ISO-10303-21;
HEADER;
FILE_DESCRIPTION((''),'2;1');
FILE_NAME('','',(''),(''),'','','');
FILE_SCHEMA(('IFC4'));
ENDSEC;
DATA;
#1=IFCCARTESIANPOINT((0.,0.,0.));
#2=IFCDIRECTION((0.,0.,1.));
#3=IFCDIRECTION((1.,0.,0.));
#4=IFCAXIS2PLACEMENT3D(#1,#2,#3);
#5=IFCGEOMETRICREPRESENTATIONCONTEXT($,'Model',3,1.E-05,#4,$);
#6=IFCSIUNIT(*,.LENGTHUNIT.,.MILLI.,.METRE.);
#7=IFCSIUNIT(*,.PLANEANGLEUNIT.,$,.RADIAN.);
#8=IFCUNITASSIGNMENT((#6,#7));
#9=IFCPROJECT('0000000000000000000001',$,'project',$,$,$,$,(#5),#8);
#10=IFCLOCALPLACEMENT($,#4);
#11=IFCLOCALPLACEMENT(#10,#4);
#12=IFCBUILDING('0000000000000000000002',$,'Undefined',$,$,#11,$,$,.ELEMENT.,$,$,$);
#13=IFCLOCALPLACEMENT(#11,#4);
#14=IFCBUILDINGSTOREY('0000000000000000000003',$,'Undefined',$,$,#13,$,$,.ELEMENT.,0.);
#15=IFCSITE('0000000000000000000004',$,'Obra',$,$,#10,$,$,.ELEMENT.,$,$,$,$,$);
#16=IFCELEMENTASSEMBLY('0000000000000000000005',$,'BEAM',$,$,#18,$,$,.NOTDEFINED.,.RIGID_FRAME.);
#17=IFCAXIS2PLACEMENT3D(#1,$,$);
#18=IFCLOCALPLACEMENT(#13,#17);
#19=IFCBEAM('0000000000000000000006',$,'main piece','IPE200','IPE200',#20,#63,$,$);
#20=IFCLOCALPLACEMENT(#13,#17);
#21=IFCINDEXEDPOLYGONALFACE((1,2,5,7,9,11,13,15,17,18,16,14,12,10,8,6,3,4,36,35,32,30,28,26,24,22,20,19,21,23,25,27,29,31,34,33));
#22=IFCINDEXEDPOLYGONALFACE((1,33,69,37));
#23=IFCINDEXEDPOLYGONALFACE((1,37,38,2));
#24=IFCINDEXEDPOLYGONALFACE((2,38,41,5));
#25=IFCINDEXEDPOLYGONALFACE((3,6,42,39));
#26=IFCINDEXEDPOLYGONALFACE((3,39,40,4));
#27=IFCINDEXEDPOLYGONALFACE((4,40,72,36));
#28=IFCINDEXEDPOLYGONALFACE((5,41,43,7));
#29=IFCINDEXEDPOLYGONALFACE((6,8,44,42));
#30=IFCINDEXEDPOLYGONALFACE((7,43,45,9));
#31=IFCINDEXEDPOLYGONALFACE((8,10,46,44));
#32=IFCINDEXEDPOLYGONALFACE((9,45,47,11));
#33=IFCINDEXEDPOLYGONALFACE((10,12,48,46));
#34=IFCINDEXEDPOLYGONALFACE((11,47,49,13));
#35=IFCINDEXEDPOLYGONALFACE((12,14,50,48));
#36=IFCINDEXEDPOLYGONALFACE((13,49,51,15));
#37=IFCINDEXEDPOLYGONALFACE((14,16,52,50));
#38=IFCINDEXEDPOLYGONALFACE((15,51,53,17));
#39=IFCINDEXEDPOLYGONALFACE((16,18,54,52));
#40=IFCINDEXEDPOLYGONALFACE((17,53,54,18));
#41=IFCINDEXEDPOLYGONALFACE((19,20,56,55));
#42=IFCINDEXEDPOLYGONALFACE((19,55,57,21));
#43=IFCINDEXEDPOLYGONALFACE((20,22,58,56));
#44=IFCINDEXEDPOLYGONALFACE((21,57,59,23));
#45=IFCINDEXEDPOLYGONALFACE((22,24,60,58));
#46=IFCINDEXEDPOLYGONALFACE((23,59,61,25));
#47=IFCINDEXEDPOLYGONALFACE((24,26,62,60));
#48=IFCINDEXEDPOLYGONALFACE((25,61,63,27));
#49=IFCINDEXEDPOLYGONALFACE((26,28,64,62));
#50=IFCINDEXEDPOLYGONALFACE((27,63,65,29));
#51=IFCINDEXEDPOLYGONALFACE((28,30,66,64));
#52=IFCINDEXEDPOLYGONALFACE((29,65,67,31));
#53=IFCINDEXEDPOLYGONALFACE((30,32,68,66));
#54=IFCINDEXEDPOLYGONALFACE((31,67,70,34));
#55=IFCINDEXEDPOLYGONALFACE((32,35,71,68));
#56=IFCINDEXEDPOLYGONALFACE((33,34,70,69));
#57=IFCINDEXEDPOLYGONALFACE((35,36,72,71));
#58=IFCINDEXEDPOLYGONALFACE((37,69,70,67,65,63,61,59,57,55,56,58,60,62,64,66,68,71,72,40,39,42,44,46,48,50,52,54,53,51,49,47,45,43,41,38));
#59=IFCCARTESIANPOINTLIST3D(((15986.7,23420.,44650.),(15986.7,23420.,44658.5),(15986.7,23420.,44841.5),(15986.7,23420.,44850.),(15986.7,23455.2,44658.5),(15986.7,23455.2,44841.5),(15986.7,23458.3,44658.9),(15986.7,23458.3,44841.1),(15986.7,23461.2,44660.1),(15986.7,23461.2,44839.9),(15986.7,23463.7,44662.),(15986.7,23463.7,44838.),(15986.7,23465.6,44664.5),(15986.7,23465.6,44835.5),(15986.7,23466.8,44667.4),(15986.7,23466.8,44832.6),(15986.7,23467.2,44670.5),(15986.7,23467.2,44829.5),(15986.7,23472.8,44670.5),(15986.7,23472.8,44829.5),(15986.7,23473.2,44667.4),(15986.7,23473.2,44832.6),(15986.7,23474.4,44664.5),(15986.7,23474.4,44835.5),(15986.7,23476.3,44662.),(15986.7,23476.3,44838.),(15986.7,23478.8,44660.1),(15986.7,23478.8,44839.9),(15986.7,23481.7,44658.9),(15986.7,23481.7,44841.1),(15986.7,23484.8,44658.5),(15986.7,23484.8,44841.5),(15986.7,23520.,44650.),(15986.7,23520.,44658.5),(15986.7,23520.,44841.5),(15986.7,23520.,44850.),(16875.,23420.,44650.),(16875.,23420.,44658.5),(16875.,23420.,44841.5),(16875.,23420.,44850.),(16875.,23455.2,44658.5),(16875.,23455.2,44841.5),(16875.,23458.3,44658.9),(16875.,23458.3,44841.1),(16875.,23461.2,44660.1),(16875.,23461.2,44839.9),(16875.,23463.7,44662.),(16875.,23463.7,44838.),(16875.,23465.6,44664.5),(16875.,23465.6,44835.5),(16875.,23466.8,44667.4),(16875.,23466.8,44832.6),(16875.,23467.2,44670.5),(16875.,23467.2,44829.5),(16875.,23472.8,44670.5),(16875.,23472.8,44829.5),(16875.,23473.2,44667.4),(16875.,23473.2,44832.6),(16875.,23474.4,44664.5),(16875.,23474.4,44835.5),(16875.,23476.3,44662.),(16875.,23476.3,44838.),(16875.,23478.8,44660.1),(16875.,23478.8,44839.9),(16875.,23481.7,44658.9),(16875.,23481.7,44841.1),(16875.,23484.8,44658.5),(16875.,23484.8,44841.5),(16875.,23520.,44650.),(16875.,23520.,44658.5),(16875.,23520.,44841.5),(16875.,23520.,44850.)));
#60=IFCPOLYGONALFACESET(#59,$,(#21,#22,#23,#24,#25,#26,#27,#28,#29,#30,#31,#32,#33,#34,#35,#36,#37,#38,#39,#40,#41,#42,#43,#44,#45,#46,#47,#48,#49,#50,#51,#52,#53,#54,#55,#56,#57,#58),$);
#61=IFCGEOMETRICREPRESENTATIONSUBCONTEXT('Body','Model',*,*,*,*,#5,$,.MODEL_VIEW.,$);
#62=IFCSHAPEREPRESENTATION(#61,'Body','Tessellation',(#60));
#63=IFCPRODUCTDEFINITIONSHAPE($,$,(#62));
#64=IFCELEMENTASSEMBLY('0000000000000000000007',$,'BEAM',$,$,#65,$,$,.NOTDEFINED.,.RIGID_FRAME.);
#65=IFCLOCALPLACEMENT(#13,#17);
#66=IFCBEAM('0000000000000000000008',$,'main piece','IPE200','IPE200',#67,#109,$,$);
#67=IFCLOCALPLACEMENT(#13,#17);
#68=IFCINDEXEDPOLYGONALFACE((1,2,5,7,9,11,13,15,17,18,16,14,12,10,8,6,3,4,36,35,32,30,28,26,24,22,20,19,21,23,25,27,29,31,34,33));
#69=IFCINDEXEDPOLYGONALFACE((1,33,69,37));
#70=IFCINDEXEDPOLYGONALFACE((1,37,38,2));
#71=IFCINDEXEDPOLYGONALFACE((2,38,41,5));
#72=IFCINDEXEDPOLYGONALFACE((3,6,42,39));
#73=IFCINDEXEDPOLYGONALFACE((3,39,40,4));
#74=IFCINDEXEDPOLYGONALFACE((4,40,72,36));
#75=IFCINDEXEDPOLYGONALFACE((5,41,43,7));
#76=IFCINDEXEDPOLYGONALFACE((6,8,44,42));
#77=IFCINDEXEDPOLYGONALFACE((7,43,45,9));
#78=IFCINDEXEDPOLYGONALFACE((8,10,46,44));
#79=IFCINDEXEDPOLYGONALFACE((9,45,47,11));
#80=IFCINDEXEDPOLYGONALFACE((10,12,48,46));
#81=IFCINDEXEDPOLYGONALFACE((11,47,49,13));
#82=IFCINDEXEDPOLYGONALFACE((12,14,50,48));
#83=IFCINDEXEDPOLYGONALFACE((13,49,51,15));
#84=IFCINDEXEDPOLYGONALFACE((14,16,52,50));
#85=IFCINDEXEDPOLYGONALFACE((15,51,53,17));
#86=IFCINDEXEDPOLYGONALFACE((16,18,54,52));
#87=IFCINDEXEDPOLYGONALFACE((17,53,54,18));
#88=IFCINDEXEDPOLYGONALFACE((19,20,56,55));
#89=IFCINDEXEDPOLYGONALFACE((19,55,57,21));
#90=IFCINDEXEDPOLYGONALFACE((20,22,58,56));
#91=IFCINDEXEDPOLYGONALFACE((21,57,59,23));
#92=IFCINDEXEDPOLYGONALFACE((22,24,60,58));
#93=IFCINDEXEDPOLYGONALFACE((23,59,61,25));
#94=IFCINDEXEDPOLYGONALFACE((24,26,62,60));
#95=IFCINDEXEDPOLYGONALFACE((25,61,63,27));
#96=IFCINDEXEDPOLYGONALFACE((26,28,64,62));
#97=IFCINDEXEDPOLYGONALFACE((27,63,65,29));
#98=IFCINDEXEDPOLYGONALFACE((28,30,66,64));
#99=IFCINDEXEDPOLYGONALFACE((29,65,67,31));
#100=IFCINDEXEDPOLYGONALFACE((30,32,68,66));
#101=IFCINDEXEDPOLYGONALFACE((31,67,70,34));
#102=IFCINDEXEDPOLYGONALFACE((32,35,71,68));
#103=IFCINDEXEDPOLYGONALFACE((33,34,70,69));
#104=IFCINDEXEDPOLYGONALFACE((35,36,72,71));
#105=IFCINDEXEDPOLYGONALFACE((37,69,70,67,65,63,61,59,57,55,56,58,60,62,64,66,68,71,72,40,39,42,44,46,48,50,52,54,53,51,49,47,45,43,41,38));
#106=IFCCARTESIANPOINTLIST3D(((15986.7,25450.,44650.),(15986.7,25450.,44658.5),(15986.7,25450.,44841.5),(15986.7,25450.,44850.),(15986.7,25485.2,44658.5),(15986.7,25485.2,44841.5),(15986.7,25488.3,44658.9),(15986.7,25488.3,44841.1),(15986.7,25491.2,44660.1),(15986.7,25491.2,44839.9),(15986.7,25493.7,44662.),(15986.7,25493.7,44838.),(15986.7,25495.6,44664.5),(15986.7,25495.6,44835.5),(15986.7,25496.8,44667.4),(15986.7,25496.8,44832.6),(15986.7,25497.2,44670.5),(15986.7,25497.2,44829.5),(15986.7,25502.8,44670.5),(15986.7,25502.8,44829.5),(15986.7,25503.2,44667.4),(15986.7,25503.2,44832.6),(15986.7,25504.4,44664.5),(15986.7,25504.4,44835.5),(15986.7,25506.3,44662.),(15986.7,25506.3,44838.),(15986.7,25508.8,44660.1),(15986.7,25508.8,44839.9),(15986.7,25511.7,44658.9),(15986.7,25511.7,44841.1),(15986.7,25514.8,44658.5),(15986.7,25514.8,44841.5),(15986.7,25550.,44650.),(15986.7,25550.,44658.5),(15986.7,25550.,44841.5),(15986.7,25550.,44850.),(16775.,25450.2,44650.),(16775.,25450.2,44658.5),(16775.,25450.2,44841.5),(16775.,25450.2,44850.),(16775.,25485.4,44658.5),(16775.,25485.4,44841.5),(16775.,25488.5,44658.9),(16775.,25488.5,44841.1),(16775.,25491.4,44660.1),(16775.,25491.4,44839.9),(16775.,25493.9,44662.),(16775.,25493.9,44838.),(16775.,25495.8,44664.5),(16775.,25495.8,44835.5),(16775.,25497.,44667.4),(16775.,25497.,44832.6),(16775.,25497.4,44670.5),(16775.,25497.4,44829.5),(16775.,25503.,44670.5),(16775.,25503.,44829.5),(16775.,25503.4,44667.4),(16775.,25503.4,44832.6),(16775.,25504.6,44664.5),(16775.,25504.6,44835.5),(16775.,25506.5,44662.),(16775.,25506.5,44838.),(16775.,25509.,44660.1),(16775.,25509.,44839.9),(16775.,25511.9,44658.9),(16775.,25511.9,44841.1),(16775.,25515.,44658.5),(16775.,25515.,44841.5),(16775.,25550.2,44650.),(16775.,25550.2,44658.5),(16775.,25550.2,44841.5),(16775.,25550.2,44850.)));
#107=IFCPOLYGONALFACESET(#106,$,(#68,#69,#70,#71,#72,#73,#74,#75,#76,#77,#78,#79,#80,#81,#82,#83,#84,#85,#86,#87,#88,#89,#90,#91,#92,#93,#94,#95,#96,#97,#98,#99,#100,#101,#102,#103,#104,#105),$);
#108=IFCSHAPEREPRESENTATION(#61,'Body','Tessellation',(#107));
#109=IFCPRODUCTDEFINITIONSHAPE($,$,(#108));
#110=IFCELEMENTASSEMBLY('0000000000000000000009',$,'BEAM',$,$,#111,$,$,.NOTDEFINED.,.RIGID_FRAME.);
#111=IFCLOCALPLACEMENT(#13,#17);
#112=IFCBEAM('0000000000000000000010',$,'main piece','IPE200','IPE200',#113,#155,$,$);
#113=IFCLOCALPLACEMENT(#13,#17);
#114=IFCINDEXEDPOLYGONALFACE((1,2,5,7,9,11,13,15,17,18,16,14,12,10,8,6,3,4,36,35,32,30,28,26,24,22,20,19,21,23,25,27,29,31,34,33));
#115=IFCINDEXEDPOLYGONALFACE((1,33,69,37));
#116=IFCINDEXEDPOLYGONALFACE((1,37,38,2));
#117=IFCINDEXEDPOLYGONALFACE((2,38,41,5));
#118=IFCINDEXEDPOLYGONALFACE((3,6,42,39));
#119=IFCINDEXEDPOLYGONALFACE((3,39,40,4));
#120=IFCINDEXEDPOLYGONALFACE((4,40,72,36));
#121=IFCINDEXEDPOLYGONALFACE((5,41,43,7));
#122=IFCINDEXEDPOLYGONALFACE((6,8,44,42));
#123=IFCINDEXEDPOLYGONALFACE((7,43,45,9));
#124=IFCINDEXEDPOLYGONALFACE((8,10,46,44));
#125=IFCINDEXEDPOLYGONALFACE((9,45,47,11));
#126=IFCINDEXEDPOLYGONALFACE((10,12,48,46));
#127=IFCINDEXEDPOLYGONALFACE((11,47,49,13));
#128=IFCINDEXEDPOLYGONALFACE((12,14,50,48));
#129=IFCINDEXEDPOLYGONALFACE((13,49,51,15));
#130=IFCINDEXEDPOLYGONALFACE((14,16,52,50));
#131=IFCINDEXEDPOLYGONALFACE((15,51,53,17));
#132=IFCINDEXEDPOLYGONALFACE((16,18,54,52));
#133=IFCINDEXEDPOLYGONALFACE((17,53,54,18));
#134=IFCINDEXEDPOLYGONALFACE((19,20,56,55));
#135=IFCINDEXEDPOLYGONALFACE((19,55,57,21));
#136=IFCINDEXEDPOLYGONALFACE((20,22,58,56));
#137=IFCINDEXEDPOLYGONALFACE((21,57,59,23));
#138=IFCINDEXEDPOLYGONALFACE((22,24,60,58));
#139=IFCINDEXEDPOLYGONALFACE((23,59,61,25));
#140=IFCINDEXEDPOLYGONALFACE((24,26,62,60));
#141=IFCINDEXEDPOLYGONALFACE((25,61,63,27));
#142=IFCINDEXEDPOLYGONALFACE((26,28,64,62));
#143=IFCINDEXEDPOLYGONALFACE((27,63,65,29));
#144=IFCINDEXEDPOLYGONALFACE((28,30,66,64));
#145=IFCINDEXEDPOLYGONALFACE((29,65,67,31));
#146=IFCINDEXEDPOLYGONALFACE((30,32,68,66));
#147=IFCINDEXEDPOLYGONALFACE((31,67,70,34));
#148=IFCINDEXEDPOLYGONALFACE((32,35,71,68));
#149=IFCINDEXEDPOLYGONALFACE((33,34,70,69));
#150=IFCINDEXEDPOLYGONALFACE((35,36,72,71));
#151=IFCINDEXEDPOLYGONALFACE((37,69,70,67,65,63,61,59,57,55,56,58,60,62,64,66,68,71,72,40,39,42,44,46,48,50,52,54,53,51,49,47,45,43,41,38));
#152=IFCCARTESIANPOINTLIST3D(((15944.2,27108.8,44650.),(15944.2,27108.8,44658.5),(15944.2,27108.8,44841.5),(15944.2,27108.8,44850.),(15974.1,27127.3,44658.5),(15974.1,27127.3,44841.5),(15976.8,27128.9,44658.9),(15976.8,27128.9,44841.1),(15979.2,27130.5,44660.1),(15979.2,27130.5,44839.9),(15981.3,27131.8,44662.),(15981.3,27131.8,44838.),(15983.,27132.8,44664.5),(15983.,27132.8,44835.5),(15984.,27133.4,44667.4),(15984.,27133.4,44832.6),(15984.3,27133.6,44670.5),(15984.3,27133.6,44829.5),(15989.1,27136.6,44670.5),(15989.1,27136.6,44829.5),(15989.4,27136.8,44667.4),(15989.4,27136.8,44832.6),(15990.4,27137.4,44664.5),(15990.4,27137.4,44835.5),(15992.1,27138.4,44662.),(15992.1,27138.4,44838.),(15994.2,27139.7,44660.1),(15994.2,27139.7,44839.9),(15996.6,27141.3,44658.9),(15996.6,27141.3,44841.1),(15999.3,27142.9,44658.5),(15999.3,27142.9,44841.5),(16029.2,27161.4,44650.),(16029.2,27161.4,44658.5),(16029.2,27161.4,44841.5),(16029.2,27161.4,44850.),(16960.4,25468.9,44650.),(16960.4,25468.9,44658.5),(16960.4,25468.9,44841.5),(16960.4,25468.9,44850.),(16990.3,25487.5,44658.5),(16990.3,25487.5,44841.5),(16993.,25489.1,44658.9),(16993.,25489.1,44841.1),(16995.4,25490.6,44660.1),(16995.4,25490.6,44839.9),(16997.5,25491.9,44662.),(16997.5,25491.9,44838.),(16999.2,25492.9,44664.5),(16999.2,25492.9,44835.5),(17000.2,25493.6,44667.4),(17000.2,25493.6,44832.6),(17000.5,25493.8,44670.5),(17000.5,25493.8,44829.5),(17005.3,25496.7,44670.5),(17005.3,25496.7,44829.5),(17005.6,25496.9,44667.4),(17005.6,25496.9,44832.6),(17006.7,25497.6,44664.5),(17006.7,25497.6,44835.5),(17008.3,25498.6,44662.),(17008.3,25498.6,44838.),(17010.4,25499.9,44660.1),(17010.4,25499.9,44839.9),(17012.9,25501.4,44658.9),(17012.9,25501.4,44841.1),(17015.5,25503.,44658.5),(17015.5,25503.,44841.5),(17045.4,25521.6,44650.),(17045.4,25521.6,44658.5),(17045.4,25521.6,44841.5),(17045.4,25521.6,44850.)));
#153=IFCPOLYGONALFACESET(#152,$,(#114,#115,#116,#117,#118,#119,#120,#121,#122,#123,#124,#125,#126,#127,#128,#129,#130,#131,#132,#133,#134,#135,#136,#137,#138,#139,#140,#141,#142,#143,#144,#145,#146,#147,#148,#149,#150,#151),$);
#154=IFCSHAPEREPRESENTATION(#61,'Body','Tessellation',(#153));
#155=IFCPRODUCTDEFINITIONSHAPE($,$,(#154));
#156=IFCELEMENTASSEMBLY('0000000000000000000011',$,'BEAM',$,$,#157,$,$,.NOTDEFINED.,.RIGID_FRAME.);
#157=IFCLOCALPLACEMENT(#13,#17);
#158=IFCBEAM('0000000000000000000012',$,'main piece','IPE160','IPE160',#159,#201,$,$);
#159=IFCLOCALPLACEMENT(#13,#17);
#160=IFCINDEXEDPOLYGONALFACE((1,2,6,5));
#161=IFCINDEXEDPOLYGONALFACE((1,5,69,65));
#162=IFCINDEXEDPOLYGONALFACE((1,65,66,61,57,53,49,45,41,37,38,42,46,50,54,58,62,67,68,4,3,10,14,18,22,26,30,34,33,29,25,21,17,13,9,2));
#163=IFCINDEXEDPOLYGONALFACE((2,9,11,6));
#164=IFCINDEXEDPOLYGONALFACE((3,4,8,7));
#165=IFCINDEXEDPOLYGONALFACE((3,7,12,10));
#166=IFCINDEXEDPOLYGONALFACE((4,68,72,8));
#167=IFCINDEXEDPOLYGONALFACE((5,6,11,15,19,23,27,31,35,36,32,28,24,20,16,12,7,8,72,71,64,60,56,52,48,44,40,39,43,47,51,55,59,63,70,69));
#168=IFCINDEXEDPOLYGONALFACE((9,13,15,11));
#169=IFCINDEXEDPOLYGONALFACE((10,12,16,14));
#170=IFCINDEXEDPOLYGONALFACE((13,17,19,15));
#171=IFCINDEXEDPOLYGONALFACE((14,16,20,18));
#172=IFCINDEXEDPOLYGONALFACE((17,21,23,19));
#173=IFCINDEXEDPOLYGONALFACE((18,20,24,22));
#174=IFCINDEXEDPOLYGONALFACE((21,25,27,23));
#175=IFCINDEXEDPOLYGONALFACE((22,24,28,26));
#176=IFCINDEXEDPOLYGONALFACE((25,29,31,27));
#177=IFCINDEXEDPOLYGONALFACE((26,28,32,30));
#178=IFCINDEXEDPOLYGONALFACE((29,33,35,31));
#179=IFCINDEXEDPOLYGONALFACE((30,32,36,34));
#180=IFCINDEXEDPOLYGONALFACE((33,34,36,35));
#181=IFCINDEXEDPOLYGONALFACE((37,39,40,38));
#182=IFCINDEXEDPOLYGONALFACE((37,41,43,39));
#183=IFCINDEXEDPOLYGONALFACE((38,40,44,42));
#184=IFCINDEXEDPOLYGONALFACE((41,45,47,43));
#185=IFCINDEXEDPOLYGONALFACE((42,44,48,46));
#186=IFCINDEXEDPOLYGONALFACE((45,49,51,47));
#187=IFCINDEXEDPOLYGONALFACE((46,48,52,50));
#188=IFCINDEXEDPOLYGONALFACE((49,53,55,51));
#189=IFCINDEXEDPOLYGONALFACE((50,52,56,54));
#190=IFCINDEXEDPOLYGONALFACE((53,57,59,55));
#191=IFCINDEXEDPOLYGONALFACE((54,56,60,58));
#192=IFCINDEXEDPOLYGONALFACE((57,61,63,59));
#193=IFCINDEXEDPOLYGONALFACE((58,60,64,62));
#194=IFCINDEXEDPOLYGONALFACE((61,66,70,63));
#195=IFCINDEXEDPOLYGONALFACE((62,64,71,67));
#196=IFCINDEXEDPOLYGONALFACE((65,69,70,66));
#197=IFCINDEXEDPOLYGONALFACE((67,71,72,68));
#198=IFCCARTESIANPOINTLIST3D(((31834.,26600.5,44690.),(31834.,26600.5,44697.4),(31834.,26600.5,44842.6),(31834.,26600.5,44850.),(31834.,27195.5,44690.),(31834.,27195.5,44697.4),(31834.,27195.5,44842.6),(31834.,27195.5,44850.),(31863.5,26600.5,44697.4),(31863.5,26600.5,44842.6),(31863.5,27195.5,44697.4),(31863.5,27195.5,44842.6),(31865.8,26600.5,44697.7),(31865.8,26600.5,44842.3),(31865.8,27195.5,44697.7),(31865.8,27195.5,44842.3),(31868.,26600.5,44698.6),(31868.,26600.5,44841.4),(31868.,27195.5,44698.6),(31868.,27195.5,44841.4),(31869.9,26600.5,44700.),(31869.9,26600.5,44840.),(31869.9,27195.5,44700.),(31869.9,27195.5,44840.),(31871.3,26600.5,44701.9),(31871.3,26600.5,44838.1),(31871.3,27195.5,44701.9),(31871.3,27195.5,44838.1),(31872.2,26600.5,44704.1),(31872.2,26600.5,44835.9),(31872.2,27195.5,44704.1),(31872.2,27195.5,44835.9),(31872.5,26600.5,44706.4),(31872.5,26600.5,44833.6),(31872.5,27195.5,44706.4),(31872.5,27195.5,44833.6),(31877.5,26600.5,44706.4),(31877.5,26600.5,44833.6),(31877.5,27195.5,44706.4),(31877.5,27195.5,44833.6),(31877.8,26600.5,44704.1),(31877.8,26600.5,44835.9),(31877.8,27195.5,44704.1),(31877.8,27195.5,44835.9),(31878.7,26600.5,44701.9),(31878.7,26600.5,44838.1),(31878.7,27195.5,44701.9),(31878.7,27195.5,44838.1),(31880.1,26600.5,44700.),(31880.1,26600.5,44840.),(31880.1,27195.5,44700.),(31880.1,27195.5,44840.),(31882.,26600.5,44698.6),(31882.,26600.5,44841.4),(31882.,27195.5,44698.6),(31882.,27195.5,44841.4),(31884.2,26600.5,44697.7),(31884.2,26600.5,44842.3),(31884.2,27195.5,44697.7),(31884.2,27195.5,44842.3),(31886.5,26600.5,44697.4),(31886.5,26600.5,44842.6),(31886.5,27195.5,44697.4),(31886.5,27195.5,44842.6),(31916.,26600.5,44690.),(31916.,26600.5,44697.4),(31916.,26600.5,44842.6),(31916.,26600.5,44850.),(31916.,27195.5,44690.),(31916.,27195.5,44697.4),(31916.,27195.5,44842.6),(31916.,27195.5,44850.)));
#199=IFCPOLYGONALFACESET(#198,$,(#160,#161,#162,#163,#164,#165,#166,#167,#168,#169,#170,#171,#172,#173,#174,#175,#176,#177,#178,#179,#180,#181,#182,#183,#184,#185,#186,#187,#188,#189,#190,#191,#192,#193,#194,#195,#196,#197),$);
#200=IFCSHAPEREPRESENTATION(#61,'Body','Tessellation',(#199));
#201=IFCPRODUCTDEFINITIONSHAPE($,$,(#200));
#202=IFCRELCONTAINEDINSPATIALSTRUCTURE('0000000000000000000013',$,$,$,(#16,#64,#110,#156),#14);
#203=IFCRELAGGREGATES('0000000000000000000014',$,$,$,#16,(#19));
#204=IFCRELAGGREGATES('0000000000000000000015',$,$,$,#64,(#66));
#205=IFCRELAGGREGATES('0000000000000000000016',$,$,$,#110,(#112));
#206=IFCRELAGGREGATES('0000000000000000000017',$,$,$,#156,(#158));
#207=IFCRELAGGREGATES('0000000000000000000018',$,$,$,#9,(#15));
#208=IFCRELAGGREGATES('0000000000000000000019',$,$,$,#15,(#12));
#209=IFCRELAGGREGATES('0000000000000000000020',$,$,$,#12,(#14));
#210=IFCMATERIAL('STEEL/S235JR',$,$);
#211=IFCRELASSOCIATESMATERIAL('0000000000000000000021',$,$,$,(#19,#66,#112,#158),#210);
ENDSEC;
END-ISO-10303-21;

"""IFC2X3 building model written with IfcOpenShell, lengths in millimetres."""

from ifc_helpers import new_model, si_unit, frame, origin_with_axes, origin_2d_with_axis, place, context, subcontext, project, spatial, i_section, extrude, material, element, aggregate, save


model = new_model("IFC2X3")

# Units and contexts
model_context = context("Model", 3, precision=1e-05, world=origin_with_axes())
body_context = subcontext(model_context, "Body", "Model", "MODEL_VIEW")
ifc_project = project(units=[si_unit("LENGTHUNIT", "METRE", prefix="MILLI"), si_unit("PLANEANGLEUNIT", "RADIAN")], contexts=[model_context])

# Site, building, storey
site_placement = place(None, origin_with_axes())
site = spatial("IfcSite", under=ifc_project, at=site_placement, Name="Obra", CompositionType="ELEMENT")
building_placement = place(site_placement, origin_with_axes())
building = spatial("IfcBuilding", under=site, at=building_placement, Name="Undefined", CompositionType="ELEMENT")
storey_placement = place(building_placement, origin_with_axes())
storey = spatial("IfcBuildingStorey", under=building, at=storey_placement, Name="Undefined", CompositionType="ELEMENT", Elevation=0.0)

# Shared definitions
ifc_material_1 = material(Name="STEEL/S235JR")

# Element assemblies, beams
assembly_1_placement = place(storey_placement, origin_with_axes())
assembly_1 = element("IfcElementAssembly", 1, at=assembly_1_placement, inside=storey, Name="BEAM", AssemblyPlace="NOTDEFINED", PredefinedType="RIGID_FRAME")
beam_1_placement = place(assembly_1_placement, frame((15986.7, 23470.0, 44750.0), z_axis=(0.0, 0.0, 1.0), x_axis=(1.0, 0.0, 0.0)))
beam_1 = element("IfcBeam", 2, at=beam_1_placement, material=ifc_material_1, Name="main piece", Description="IPE200", ObjectType="IPE200", context=body_context, shape_type="SweptSolid", body=[
    extrude(i_section(OverallWidth=100.0, OverallDepth=200.0, WebThickness=5.6, FlangeThickness=8.5, FilletRadius=12.0, at=origin_2d_with_axis()), frame((888.3, 0.0, 0.0), z_axis=(-1.0, 0.0, 0.0), x_axis=(0.0, -1.0, 0.0)), (0.0, 0.0, 1.0), 888.3),
])
aggregate(assembly_1, [beam_1])
assembly_2_placement = place(storey_placement, origin_with_axes())
assembly_2 = element("IfcElementAssembly", 3, at=assembly_2_placement, inside=storey, Name="BEAM", AssemblyPlace="NOTDEFINED", PredefinedType="RIGID_FRAME")
beam_2_placement = place(assembly_2_placement, frame((16775.0, 25500.2, 44750.0), z_axis=(0.0, 0.0, 1.0), x_axis=(-1.0, -0.000266, 0.0)))
beam_2 = element("IfcBeam", 4, at=beam_2_placement, material=ifc_material_1, Name="main piece", Description="IPE200", ObjectType="IPE200", context=body_context, shape_type="SweptSolid", body=[
    extrude(i_section(OverallWidth=100.0, OverallDepth=200.0, WebThickness=5.6, FlangeThickness=8.5, FilletRadius=12.0, at=origin_2d_with_axis()), frame((788.3, 0.0, 0.0), z_axis=(-1.0, 0.0, 0.0), x_axis=(0.0, -1.0, 0.0)), (0.0, 0.0, 1.0), 788.3),
])
aggregate(assembly_2, [beam_2])
assembly_3_placement = place(storey_placement, origin_with_axes())
assembly_3 = element("IfcElementAssembly", 5, at=assembly_3_placement, inside=storey, Name="BEAM", AssemblyPlace="NOTDEFINED", PredefinedType="RIGID_FRAME")
beam_3_placement = place(assembly_3_placement, frame((17002.9, 25495.3, 44750.0), z_axis=(0.0, 0.0, 1.0), x_axis=(-0.526756, 0.850017, 0.0)))
beam_3 = element("IfcBeam", 6, at=beam_3_placement, material=ifc_material_1, Name="main piece", Description="IPE200", ObjectType="IPE200", context=body_context, shape_type="SweptSolid", body=[
    extrude(i_section(OverallWidth=100.0, OverallDepth=200.0, WebThickness=5.6, FlangeThickness=8.5, FilletRadius=12.0, at=origin_2d_with_axis()), frame((1929.2, 0.0, 0.0), z_axis=(-1.0, 0.0, 0.0), x_axis=(0.0, -1.0, 0.0)), (0.0, 0.0, 1.0), 1929.2),
])
aggregate(assembly_3, [beam_3])
assembly_4_placement = place(storey_placement, origin_with_axes())
assembly_4 = element("IfcElementAssembly", 7, at=assembly_4_placement, inside=storey, Name="BEAM", AssemblyPlace="NOTDEFINED", PredefinedType="RIGID_FRAME")
beam_4_placement = place(assembly_4_placement, frame((31875.0, 26600.5, 44770.0), z_axis=(0.0, 0.0, 1.0), x_axis=(0.0, 1.0, 0.0)))
beam_4 = element("IfcBeam", 8, at=beam_4_placement, material=ifc_material_1, Name="main piece", Description="IPE160", ObjectType="IPE160", context=body_context, shape_type="SweptSolid", body=[
    extrude(i_section(OverallWidth=82.0, OverallDepth=160.0, WebThickness=5.0, FlangeThickness=7.4, FilletRadius=9.0, at=origin_2d_with_axis()), frame((595.0, 0.0, 0.0), z_axis=(-1.0, 0.0, 0.0), x_axis=(0.0, -1.0, 0.0)), (0.0, 0.0, 1.0), 595.0),
])
aggregate(assembly_4, [beam_4])

save(model, "model.ifc")
